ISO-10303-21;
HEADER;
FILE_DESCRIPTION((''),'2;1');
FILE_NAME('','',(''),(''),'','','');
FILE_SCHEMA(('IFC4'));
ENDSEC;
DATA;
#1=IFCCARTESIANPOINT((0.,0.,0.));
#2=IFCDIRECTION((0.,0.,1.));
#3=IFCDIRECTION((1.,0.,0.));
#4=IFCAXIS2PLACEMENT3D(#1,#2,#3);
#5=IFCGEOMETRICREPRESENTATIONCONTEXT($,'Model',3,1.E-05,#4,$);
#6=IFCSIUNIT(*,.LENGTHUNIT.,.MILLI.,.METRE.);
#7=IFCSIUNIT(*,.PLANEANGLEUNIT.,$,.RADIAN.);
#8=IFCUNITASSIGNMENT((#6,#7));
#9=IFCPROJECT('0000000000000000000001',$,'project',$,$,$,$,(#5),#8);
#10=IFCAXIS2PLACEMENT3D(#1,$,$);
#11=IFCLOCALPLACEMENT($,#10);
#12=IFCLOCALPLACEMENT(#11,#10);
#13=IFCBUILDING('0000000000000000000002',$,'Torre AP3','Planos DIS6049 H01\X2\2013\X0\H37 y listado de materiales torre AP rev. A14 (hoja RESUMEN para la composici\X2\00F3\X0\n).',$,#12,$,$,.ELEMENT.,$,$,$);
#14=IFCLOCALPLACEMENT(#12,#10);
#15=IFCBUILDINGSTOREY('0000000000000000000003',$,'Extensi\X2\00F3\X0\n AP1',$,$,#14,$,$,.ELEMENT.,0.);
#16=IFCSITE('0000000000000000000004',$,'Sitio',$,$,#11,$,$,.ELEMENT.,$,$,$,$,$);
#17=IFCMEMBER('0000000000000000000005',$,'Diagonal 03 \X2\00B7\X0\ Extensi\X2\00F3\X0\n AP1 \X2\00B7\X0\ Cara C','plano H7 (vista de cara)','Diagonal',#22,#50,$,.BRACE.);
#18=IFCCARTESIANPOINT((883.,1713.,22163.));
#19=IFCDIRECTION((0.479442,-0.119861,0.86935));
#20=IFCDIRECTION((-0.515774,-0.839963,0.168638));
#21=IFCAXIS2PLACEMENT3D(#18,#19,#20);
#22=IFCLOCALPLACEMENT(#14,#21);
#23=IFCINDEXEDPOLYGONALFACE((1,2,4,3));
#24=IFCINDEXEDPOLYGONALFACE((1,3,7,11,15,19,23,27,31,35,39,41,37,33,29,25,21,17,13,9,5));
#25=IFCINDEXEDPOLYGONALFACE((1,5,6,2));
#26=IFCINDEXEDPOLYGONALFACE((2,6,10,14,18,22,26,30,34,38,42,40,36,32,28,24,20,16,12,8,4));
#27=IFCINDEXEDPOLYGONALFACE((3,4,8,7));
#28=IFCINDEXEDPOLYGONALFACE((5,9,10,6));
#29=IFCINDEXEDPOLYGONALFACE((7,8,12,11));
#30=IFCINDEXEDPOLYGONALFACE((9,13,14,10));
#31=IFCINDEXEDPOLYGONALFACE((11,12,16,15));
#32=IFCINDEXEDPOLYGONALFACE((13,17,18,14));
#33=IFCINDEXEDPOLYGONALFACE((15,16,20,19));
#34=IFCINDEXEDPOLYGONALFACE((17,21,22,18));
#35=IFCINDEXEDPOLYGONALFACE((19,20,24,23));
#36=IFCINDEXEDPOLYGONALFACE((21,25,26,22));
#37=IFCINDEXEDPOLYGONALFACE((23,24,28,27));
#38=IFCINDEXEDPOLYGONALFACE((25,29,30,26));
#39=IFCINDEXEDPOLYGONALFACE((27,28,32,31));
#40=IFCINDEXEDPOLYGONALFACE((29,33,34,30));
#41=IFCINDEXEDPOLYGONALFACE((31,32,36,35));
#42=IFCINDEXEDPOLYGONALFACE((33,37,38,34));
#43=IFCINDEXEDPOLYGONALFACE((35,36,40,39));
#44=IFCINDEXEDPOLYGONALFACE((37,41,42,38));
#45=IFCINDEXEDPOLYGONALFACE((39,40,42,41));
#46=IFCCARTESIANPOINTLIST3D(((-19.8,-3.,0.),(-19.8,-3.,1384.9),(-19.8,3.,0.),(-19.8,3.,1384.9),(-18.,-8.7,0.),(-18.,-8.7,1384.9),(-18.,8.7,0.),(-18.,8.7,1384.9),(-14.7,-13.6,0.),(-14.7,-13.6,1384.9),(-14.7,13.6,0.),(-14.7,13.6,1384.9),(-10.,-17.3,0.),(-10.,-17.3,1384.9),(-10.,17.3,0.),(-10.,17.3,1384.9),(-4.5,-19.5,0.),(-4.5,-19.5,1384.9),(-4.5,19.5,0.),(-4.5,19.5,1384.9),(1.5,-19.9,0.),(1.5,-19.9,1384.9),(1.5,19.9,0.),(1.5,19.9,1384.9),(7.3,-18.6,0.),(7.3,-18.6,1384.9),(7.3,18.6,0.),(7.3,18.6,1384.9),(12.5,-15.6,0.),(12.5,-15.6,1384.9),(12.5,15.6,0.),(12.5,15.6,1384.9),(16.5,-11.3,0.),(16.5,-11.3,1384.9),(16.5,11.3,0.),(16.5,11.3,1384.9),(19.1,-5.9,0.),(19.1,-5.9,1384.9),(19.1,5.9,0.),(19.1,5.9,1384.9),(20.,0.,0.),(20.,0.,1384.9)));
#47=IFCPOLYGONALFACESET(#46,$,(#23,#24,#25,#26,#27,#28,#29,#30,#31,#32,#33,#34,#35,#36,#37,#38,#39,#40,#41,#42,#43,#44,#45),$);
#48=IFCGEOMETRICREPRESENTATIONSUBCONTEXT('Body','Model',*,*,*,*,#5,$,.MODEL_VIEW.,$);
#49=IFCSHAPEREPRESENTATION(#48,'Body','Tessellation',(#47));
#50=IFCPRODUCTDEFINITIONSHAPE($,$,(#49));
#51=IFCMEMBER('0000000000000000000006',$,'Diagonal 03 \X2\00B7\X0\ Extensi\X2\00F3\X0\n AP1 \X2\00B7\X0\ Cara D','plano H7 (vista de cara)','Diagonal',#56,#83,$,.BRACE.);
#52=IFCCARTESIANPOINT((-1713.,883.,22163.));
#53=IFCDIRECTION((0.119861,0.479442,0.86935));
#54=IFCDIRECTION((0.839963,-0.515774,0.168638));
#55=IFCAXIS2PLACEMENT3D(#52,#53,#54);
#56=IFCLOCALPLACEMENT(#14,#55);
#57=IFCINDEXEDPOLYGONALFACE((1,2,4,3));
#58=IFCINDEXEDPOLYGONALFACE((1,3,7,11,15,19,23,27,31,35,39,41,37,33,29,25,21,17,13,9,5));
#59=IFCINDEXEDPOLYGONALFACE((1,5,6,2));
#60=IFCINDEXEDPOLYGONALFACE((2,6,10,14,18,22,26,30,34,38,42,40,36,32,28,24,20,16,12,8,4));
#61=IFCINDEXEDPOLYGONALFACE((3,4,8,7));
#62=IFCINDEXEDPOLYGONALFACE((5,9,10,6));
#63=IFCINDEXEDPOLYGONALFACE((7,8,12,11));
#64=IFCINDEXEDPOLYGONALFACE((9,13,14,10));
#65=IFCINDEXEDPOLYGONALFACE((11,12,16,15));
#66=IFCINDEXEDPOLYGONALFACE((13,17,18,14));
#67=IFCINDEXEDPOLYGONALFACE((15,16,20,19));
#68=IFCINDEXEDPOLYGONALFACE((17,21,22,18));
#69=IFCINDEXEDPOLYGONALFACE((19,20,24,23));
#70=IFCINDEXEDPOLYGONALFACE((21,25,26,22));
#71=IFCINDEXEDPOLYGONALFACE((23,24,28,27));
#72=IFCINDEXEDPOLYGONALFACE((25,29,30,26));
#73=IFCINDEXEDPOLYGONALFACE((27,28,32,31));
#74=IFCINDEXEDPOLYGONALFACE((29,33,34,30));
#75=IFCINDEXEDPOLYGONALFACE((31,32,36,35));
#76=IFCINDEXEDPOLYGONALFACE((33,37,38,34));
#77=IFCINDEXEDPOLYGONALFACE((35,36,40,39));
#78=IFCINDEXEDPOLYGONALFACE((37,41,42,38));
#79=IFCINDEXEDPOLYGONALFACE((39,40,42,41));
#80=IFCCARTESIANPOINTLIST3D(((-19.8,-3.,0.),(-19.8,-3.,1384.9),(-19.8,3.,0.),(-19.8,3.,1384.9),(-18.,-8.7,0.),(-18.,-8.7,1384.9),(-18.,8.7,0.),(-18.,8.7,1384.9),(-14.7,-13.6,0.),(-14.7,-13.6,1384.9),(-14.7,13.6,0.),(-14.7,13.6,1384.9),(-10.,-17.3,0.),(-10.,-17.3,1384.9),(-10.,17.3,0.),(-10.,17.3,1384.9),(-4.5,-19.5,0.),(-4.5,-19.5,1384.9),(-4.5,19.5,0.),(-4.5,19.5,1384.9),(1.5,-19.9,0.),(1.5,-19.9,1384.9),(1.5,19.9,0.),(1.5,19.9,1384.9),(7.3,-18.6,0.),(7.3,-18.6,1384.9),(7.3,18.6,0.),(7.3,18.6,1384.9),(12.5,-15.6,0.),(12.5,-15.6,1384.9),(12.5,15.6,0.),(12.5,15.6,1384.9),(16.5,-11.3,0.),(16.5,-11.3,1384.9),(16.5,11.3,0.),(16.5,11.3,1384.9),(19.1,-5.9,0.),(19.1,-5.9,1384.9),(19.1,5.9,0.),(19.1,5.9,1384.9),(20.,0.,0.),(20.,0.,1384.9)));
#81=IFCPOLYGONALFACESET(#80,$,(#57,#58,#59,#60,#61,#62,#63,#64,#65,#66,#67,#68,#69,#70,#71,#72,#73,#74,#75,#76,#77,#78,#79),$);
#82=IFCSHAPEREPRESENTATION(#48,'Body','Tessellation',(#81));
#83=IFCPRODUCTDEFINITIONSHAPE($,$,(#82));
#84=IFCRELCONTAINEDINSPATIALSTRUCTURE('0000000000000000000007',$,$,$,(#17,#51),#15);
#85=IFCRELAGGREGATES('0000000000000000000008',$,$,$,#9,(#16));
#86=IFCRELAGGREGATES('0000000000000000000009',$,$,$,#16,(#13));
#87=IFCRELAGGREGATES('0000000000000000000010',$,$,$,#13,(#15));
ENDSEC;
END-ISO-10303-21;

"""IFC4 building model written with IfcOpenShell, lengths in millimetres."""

from ifc_helpers import new_model, si_unit, frame, origin, origin_with_axes, place, context, subcontext, project, spatial, circle, extrude, element, save


model = new_model("IFC4")

# Units and contexts
model_context = context("Model", 3, precision=1e-05, world=origin_with_axes())
body_context = subcontext(model_context, "Body", "Model", "MODEL_VIEW")
ifc_project = project(units=[si_unit("LENGTHUNIT", "METRE", prefix="MILLI"), si_unit("PLANEANGLEUNIT", "RADIAN")], contexts=[model_context])

# Site, building, storey
site_placement = place(None, origin())
site = spatial("IfcSite", under=ifc_project, at=site_placement, Name="Sitio", CompositionType="ELEMENT")
building_placement = place(site_placement, origin())
building = spatial("IfcBuilding", under=site, at=building_placement, Name="Torre AP3", Description="Planos DIS6049 H01–H37 y listado de materiales torre AP rev. A14 (hoja RESUMEN para la composición).", CompositionType="ELEMENT")
storey_placement = place(building_placement, origin())
storey = spatial("IfcBuildingStorey", under=building, at=storey_placement, Name="Extensión AP1", CompositionType="ELEMENT", Elevation=0.0)

# Members
for number, where, z_axis, x_axis, name in (
    (1, (883.0, 1713.0, 22163.0), (0.479442, -0.119861, 0.86935), (-0.515774, -0.839963, 0.168638), "Diagonal 03 · Extensión AP1 · Cara C"),
    (2, (-1713.0, 883.0, 22163.0), (0.119861, 0.479442, 0.86935), (0.839963, -0.515774, 0.168638), "Diagonal 03 · Extensión AP1 · Cara D"),
):
    element("IfcMember", number, at=place(storey_placement, frame(where, z_axis=z_axis, x_axis=x_axis)), inside=storey, Name=name, Description="plano H7 (vista de cara)", ObjectType="Diagonal", PredefinedType="BRACE", context=body_context, shape_type="SweptSolid", body=[
        extrude(circle(Radius=20.0), None, (0.0, 0.0, 1.0), 1384.9),
    ])

save(model, "model.ifc")
